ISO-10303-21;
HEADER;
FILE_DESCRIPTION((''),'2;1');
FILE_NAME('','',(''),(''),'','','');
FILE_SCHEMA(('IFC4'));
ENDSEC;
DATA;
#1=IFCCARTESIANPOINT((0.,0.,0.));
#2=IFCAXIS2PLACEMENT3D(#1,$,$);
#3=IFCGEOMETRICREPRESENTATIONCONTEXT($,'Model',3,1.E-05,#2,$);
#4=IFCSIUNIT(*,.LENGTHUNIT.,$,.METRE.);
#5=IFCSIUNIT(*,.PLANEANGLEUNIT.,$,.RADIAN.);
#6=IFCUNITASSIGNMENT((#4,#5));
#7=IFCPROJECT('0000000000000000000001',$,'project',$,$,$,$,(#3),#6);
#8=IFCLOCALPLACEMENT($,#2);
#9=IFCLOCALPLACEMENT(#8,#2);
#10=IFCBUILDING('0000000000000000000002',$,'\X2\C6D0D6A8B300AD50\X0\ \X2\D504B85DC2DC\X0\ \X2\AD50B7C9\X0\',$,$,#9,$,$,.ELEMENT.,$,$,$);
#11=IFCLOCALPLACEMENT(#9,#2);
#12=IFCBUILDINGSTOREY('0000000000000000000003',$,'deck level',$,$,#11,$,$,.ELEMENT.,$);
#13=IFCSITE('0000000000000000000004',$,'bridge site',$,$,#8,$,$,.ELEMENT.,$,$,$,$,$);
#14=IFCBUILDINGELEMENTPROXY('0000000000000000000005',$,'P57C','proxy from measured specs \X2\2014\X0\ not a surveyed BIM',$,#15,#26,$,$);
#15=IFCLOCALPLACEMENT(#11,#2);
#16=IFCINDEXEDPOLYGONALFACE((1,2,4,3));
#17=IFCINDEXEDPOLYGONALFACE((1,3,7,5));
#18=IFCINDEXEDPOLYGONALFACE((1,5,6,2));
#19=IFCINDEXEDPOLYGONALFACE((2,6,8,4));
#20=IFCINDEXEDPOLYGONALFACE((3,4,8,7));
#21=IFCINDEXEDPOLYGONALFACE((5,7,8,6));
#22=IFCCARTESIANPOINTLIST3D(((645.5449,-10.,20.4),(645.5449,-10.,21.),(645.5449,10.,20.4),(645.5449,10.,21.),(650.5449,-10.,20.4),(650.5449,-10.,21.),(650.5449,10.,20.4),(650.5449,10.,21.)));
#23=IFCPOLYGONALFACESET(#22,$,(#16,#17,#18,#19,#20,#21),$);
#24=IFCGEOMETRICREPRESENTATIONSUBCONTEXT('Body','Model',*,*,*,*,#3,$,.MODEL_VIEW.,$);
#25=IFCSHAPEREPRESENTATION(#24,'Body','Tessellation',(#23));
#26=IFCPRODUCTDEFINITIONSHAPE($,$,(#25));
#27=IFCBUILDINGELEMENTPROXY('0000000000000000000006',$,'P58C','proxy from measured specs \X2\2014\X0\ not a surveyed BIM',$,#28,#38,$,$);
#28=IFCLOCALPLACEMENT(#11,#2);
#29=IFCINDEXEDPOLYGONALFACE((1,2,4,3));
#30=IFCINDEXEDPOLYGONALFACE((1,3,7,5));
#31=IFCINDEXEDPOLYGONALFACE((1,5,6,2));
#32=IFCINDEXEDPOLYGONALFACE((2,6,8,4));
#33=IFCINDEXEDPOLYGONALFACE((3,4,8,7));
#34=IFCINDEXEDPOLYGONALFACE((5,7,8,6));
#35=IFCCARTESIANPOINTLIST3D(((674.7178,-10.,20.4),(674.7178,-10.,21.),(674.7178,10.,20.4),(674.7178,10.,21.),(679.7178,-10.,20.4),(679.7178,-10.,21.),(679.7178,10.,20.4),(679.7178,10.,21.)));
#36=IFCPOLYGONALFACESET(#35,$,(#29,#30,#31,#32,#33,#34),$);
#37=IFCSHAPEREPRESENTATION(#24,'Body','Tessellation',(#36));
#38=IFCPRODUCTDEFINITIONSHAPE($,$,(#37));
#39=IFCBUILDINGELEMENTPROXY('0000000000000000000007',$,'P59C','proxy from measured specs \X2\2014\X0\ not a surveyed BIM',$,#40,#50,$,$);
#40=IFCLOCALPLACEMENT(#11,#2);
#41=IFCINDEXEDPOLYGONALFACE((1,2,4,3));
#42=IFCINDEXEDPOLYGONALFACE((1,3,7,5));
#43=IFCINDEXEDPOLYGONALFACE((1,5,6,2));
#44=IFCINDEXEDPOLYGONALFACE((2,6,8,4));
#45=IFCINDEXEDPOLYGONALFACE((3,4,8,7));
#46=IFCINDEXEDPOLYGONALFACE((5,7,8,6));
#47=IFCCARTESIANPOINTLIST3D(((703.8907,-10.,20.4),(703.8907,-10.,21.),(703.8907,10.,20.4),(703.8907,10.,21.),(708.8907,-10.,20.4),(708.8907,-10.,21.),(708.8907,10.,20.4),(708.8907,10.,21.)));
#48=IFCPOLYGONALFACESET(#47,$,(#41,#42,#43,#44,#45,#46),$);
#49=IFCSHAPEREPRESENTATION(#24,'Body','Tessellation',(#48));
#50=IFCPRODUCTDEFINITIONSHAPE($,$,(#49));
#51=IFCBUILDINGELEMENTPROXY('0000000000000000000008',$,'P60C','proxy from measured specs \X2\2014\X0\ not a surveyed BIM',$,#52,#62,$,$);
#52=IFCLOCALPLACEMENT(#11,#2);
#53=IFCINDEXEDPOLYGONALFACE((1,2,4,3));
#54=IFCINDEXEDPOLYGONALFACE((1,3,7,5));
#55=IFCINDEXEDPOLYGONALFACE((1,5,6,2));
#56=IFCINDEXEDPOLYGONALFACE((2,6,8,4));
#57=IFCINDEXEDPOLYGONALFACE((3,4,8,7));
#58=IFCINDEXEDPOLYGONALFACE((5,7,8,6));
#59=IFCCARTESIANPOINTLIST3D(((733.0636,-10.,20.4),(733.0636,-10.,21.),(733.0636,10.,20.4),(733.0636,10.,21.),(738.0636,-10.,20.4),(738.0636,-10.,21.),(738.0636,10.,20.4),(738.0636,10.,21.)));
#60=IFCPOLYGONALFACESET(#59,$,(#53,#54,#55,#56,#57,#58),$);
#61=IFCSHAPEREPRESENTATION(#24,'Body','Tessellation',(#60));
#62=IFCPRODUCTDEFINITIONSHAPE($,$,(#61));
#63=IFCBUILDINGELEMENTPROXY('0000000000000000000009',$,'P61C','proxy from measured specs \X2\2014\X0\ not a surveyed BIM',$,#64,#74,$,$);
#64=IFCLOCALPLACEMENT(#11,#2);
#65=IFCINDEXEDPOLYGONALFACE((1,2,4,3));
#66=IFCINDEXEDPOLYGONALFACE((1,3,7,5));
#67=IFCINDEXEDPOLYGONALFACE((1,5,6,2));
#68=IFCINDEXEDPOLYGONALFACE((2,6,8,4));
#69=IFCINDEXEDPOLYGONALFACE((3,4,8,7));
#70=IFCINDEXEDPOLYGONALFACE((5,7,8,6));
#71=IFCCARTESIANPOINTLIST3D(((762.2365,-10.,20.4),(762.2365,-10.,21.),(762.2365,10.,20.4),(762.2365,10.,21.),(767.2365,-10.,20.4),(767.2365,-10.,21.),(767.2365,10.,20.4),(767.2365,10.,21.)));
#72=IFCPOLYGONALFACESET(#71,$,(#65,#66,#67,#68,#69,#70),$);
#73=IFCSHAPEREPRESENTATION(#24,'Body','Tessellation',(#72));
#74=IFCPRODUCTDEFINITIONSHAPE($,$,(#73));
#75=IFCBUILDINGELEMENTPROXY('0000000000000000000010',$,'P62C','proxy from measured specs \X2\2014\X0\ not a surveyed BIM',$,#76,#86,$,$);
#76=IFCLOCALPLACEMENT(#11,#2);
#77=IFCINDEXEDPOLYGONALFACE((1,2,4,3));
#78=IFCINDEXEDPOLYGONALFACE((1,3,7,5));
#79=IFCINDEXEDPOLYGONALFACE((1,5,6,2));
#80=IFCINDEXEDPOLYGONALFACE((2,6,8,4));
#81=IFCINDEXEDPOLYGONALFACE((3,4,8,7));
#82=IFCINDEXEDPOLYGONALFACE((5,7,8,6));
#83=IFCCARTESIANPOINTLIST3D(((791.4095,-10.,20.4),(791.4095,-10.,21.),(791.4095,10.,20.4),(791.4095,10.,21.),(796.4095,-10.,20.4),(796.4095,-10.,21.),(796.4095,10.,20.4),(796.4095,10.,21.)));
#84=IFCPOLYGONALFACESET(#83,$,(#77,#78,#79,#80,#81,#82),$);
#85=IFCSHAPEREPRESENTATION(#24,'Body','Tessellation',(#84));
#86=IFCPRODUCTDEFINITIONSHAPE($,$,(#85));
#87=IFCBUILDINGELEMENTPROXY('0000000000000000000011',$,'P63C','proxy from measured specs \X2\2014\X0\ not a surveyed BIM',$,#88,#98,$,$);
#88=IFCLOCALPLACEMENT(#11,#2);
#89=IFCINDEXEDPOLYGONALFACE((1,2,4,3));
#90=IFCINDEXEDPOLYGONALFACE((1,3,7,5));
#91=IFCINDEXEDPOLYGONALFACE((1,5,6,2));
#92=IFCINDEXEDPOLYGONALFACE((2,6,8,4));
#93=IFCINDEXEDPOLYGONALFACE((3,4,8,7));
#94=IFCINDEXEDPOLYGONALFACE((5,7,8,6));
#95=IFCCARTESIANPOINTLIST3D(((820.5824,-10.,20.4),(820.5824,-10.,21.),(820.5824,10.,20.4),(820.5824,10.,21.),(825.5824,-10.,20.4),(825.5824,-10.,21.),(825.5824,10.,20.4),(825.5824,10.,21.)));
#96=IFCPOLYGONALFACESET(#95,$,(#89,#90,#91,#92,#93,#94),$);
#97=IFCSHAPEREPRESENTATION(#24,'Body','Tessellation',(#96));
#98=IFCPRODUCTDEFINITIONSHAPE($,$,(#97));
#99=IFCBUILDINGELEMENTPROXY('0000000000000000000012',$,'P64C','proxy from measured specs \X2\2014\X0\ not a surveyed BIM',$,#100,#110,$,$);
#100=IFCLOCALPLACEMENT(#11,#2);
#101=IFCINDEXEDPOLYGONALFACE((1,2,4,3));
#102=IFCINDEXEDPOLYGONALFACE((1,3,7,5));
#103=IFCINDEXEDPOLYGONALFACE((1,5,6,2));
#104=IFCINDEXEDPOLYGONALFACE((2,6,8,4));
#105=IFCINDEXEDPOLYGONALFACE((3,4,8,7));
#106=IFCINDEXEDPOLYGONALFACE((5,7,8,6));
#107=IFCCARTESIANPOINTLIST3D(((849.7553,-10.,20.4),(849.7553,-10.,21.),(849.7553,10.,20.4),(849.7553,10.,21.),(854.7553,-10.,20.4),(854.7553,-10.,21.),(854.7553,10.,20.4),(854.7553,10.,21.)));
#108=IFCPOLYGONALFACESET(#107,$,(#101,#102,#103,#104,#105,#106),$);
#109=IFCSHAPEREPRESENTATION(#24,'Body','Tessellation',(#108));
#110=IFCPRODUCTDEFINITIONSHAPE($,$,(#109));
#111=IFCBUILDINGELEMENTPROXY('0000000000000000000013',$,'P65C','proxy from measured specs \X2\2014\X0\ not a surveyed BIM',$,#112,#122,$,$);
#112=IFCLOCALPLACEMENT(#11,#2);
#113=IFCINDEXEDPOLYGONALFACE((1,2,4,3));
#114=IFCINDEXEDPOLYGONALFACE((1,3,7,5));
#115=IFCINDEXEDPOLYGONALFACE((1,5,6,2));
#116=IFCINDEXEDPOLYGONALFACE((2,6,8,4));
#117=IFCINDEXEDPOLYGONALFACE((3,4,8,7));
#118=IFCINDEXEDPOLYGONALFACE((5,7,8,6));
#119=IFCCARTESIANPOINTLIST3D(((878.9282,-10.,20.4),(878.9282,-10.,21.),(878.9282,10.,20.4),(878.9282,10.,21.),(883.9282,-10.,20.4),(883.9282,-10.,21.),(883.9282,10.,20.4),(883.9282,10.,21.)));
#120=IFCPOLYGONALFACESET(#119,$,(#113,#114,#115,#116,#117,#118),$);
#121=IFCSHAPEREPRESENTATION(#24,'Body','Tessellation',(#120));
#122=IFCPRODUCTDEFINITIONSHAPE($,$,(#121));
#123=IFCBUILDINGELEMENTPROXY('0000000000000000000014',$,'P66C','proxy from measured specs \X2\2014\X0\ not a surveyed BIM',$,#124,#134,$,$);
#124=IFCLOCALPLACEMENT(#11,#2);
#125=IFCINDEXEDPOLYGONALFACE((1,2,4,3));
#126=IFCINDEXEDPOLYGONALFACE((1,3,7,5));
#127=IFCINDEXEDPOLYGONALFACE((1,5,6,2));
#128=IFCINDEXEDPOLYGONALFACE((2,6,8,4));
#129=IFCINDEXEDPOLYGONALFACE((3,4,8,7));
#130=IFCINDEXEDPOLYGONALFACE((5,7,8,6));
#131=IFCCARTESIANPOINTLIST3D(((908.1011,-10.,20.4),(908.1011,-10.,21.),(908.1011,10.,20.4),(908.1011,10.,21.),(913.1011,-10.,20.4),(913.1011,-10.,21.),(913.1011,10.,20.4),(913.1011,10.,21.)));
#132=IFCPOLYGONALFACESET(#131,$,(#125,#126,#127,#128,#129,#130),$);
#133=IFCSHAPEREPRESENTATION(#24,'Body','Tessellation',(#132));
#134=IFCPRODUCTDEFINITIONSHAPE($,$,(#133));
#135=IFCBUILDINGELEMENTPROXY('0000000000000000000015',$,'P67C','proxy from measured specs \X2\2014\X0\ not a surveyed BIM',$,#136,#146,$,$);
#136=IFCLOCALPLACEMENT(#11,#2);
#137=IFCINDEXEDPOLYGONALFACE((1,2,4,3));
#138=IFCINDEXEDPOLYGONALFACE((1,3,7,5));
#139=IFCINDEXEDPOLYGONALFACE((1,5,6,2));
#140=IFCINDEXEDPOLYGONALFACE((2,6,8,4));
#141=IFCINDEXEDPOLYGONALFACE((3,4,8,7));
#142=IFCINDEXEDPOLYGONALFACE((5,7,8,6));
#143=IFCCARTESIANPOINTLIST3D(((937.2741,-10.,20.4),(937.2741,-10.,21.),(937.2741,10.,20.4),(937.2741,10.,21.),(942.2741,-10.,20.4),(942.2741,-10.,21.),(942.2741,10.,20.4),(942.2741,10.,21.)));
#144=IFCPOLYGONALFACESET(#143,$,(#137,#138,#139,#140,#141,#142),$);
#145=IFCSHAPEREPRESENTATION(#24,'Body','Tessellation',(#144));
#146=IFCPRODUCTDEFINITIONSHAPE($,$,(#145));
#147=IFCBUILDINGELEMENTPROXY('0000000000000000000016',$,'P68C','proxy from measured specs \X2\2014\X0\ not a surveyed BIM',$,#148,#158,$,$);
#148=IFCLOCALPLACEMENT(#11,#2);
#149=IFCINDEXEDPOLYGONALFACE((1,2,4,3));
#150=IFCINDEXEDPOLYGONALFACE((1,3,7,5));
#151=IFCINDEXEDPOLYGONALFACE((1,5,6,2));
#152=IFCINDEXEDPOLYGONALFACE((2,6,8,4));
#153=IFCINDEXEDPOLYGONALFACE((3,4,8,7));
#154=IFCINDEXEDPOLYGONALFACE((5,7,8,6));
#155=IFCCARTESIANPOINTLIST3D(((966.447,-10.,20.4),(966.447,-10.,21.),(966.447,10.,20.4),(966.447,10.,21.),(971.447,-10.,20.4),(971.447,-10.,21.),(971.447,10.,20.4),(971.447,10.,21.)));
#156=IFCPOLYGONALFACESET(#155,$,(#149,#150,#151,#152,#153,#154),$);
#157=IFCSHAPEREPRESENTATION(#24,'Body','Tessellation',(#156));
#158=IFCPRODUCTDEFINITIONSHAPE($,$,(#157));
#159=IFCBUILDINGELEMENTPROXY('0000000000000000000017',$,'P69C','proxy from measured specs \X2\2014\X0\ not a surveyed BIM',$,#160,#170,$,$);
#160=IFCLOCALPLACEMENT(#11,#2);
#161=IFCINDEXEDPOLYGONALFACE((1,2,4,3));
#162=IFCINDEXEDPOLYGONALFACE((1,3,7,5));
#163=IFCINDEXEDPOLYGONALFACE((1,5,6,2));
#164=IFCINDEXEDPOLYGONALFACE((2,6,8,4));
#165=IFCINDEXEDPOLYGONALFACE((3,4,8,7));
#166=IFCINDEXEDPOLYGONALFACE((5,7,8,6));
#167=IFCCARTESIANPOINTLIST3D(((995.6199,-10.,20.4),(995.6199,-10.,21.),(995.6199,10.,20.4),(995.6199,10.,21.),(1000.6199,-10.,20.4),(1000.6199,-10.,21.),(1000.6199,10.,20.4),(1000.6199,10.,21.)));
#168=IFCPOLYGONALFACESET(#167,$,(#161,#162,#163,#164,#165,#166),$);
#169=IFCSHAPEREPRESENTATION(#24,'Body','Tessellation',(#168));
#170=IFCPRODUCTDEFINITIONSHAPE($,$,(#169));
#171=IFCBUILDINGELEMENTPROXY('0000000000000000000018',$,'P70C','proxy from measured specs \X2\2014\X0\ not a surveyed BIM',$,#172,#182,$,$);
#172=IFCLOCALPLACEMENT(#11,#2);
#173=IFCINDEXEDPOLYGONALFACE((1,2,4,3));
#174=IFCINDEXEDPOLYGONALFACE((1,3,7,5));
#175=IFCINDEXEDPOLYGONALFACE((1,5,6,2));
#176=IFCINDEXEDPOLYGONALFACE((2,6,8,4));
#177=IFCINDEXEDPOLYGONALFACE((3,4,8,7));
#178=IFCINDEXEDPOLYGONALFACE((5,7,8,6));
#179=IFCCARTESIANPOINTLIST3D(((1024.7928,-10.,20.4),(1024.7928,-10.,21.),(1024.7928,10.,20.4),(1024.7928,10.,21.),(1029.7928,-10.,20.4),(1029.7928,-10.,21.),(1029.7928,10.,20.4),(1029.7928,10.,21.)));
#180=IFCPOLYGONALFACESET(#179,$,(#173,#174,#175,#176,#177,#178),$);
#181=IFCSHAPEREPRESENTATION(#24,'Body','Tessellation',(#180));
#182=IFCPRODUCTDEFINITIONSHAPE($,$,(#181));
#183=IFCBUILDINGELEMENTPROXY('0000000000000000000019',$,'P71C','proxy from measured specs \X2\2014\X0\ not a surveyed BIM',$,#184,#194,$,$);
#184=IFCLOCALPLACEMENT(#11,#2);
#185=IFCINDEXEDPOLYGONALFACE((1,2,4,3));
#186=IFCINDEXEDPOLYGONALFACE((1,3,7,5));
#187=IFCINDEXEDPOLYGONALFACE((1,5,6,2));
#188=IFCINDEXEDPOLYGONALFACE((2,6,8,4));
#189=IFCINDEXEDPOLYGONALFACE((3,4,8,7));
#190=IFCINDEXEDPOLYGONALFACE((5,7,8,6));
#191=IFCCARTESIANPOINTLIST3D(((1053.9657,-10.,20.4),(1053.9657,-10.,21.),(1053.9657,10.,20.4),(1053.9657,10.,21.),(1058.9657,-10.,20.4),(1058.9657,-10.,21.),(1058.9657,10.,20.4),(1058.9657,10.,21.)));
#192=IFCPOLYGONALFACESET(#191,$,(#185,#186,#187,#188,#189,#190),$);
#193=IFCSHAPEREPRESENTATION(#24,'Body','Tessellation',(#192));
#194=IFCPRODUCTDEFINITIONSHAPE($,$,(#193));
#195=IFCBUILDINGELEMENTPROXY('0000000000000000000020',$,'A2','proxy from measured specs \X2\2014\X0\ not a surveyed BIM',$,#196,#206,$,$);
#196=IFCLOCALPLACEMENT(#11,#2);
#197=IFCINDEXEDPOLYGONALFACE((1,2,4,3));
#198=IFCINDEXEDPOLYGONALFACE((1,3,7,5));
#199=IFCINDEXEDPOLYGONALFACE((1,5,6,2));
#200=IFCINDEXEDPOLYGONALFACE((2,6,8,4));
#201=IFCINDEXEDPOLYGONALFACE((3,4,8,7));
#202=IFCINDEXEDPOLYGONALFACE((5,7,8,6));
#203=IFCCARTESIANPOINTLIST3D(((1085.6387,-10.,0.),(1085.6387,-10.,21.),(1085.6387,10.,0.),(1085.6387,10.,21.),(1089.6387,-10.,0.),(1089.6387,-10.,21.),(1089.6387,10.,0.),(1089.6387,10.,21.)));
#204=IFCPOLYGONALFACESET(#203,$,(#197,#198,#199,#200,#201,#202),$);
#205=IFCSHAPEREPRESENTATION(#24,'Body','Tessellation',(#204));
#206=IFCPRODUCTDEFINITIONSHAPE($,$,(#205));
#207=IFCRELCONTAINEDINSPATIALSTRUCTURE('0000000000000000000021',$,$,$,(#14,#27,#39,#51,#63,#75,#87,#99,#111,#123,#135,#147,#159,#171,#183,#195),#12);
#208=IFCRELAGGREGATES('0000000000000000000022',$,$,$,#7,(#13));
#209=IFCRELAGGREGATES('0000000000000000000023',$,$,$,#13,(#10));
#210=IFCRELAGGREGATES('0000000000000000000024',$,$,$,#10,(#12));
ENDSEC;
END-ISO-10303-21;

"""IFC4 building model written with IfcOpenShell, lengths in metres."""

from ifc_helpers import new_model, si_unit, frame, origin, origin_2d, place, context, subcontext, project, spatial, rectangle, extrude, element, save


model = new_model("IFC4")

# Units and contexts
model_context = context("Model", 3, precision=1e-05, world=origin())
body_context = subcontext(model_context, "Body", "Model", "MODEL_VIEW")
ifc_project = project(units=[si_unit("LENGTHUNIT", "METRE"), si_unit("PLANEANGLEUNIT", "RADIAN")], contexts=[model_context])

# Site, building, storey
site_placement = place(None, origin())
site = spatial("IfcSite", under=ifc_project, at=site_placement, Name="bridge site", CompositionType="ELEMENT")
building_placement = place(site_placement, origin())
building = spatial("IfcBuilding", under=site, at=building_placement, Name="원효대교 프록시 교량", CompositionType="ELEMENT")
storey_placement = place(building_placement, origin())
storey = spatial("IfcBuildingStorey", under=building, at=storey_placement, Name="deck level", CompositionType="ELEMENT")

# Building element proxies
for number, where, name in (
    (1, (648.0449, 0.0, 20.4), "P57C"),
    (2, (677.2178, 0.0, 20.4), "P58C"),
    (3, (706.3907, 0.0, 20.4), "P59C"),
    (4, (735.5636, 0.0, 20.4), "P60C"),
    (5, (764.7365, 0.0, 20.4), "P61C"),
    (6, (793.9095, 0.0, 20.4), "P62C"),
    (7, (823.0824, 0.0, 20.4), "P63C"),
    (8, (852.2553, 0.0, 20.4), "P64C"),
    (9, (881.4282, 0.0, 20.4), "P65C"),
    (10, (910.6011, 0.0, 20.4), "P66C"),
    (11, (939.7741, 0.0, 20.4), "P67C"),
    (12, (968.947, 0.0, 20.4), "P68C"),
    (13, (998.1199, 0.0, 20.4), "P69C"),
    (14, (1027.2928, 0.0, 20.4), "P70C"),
    (15, (1056.4657, 0.0, 20.4), "P71C"),
):
    element("IfcBuildingElementProxy", number, at=place(storey_placement, frame(where)), inside=storey, Name=name, Description="proxy from measured specs — not a surveyed BIM", context=body_context, shape_type="SweptSolid", body=[
        extrude(rectangle(XDim=5.0, YDim=20.0, at=origin_2d()), origin(), (0.0, 0.0, 1.0), 0.6),
    ])
proxy_placement = place(storey_placement, frame((1087.6387, 0.0, 0.0)))
element("IfcBuildingElementProxy", 16, at=proxy_placement, inside=storey, Name="A2", Description="proxy from measured specs — not a surveyed BIM", context=body_context, shape_type="SweptSolid", body=[
    extrude(rectangle(XDim=4.0, YDim=20.0, at=origin_2d()), origin(), (0.0, 0.0, 1.0), 21.0),
])

save(model, "model.ifc")
